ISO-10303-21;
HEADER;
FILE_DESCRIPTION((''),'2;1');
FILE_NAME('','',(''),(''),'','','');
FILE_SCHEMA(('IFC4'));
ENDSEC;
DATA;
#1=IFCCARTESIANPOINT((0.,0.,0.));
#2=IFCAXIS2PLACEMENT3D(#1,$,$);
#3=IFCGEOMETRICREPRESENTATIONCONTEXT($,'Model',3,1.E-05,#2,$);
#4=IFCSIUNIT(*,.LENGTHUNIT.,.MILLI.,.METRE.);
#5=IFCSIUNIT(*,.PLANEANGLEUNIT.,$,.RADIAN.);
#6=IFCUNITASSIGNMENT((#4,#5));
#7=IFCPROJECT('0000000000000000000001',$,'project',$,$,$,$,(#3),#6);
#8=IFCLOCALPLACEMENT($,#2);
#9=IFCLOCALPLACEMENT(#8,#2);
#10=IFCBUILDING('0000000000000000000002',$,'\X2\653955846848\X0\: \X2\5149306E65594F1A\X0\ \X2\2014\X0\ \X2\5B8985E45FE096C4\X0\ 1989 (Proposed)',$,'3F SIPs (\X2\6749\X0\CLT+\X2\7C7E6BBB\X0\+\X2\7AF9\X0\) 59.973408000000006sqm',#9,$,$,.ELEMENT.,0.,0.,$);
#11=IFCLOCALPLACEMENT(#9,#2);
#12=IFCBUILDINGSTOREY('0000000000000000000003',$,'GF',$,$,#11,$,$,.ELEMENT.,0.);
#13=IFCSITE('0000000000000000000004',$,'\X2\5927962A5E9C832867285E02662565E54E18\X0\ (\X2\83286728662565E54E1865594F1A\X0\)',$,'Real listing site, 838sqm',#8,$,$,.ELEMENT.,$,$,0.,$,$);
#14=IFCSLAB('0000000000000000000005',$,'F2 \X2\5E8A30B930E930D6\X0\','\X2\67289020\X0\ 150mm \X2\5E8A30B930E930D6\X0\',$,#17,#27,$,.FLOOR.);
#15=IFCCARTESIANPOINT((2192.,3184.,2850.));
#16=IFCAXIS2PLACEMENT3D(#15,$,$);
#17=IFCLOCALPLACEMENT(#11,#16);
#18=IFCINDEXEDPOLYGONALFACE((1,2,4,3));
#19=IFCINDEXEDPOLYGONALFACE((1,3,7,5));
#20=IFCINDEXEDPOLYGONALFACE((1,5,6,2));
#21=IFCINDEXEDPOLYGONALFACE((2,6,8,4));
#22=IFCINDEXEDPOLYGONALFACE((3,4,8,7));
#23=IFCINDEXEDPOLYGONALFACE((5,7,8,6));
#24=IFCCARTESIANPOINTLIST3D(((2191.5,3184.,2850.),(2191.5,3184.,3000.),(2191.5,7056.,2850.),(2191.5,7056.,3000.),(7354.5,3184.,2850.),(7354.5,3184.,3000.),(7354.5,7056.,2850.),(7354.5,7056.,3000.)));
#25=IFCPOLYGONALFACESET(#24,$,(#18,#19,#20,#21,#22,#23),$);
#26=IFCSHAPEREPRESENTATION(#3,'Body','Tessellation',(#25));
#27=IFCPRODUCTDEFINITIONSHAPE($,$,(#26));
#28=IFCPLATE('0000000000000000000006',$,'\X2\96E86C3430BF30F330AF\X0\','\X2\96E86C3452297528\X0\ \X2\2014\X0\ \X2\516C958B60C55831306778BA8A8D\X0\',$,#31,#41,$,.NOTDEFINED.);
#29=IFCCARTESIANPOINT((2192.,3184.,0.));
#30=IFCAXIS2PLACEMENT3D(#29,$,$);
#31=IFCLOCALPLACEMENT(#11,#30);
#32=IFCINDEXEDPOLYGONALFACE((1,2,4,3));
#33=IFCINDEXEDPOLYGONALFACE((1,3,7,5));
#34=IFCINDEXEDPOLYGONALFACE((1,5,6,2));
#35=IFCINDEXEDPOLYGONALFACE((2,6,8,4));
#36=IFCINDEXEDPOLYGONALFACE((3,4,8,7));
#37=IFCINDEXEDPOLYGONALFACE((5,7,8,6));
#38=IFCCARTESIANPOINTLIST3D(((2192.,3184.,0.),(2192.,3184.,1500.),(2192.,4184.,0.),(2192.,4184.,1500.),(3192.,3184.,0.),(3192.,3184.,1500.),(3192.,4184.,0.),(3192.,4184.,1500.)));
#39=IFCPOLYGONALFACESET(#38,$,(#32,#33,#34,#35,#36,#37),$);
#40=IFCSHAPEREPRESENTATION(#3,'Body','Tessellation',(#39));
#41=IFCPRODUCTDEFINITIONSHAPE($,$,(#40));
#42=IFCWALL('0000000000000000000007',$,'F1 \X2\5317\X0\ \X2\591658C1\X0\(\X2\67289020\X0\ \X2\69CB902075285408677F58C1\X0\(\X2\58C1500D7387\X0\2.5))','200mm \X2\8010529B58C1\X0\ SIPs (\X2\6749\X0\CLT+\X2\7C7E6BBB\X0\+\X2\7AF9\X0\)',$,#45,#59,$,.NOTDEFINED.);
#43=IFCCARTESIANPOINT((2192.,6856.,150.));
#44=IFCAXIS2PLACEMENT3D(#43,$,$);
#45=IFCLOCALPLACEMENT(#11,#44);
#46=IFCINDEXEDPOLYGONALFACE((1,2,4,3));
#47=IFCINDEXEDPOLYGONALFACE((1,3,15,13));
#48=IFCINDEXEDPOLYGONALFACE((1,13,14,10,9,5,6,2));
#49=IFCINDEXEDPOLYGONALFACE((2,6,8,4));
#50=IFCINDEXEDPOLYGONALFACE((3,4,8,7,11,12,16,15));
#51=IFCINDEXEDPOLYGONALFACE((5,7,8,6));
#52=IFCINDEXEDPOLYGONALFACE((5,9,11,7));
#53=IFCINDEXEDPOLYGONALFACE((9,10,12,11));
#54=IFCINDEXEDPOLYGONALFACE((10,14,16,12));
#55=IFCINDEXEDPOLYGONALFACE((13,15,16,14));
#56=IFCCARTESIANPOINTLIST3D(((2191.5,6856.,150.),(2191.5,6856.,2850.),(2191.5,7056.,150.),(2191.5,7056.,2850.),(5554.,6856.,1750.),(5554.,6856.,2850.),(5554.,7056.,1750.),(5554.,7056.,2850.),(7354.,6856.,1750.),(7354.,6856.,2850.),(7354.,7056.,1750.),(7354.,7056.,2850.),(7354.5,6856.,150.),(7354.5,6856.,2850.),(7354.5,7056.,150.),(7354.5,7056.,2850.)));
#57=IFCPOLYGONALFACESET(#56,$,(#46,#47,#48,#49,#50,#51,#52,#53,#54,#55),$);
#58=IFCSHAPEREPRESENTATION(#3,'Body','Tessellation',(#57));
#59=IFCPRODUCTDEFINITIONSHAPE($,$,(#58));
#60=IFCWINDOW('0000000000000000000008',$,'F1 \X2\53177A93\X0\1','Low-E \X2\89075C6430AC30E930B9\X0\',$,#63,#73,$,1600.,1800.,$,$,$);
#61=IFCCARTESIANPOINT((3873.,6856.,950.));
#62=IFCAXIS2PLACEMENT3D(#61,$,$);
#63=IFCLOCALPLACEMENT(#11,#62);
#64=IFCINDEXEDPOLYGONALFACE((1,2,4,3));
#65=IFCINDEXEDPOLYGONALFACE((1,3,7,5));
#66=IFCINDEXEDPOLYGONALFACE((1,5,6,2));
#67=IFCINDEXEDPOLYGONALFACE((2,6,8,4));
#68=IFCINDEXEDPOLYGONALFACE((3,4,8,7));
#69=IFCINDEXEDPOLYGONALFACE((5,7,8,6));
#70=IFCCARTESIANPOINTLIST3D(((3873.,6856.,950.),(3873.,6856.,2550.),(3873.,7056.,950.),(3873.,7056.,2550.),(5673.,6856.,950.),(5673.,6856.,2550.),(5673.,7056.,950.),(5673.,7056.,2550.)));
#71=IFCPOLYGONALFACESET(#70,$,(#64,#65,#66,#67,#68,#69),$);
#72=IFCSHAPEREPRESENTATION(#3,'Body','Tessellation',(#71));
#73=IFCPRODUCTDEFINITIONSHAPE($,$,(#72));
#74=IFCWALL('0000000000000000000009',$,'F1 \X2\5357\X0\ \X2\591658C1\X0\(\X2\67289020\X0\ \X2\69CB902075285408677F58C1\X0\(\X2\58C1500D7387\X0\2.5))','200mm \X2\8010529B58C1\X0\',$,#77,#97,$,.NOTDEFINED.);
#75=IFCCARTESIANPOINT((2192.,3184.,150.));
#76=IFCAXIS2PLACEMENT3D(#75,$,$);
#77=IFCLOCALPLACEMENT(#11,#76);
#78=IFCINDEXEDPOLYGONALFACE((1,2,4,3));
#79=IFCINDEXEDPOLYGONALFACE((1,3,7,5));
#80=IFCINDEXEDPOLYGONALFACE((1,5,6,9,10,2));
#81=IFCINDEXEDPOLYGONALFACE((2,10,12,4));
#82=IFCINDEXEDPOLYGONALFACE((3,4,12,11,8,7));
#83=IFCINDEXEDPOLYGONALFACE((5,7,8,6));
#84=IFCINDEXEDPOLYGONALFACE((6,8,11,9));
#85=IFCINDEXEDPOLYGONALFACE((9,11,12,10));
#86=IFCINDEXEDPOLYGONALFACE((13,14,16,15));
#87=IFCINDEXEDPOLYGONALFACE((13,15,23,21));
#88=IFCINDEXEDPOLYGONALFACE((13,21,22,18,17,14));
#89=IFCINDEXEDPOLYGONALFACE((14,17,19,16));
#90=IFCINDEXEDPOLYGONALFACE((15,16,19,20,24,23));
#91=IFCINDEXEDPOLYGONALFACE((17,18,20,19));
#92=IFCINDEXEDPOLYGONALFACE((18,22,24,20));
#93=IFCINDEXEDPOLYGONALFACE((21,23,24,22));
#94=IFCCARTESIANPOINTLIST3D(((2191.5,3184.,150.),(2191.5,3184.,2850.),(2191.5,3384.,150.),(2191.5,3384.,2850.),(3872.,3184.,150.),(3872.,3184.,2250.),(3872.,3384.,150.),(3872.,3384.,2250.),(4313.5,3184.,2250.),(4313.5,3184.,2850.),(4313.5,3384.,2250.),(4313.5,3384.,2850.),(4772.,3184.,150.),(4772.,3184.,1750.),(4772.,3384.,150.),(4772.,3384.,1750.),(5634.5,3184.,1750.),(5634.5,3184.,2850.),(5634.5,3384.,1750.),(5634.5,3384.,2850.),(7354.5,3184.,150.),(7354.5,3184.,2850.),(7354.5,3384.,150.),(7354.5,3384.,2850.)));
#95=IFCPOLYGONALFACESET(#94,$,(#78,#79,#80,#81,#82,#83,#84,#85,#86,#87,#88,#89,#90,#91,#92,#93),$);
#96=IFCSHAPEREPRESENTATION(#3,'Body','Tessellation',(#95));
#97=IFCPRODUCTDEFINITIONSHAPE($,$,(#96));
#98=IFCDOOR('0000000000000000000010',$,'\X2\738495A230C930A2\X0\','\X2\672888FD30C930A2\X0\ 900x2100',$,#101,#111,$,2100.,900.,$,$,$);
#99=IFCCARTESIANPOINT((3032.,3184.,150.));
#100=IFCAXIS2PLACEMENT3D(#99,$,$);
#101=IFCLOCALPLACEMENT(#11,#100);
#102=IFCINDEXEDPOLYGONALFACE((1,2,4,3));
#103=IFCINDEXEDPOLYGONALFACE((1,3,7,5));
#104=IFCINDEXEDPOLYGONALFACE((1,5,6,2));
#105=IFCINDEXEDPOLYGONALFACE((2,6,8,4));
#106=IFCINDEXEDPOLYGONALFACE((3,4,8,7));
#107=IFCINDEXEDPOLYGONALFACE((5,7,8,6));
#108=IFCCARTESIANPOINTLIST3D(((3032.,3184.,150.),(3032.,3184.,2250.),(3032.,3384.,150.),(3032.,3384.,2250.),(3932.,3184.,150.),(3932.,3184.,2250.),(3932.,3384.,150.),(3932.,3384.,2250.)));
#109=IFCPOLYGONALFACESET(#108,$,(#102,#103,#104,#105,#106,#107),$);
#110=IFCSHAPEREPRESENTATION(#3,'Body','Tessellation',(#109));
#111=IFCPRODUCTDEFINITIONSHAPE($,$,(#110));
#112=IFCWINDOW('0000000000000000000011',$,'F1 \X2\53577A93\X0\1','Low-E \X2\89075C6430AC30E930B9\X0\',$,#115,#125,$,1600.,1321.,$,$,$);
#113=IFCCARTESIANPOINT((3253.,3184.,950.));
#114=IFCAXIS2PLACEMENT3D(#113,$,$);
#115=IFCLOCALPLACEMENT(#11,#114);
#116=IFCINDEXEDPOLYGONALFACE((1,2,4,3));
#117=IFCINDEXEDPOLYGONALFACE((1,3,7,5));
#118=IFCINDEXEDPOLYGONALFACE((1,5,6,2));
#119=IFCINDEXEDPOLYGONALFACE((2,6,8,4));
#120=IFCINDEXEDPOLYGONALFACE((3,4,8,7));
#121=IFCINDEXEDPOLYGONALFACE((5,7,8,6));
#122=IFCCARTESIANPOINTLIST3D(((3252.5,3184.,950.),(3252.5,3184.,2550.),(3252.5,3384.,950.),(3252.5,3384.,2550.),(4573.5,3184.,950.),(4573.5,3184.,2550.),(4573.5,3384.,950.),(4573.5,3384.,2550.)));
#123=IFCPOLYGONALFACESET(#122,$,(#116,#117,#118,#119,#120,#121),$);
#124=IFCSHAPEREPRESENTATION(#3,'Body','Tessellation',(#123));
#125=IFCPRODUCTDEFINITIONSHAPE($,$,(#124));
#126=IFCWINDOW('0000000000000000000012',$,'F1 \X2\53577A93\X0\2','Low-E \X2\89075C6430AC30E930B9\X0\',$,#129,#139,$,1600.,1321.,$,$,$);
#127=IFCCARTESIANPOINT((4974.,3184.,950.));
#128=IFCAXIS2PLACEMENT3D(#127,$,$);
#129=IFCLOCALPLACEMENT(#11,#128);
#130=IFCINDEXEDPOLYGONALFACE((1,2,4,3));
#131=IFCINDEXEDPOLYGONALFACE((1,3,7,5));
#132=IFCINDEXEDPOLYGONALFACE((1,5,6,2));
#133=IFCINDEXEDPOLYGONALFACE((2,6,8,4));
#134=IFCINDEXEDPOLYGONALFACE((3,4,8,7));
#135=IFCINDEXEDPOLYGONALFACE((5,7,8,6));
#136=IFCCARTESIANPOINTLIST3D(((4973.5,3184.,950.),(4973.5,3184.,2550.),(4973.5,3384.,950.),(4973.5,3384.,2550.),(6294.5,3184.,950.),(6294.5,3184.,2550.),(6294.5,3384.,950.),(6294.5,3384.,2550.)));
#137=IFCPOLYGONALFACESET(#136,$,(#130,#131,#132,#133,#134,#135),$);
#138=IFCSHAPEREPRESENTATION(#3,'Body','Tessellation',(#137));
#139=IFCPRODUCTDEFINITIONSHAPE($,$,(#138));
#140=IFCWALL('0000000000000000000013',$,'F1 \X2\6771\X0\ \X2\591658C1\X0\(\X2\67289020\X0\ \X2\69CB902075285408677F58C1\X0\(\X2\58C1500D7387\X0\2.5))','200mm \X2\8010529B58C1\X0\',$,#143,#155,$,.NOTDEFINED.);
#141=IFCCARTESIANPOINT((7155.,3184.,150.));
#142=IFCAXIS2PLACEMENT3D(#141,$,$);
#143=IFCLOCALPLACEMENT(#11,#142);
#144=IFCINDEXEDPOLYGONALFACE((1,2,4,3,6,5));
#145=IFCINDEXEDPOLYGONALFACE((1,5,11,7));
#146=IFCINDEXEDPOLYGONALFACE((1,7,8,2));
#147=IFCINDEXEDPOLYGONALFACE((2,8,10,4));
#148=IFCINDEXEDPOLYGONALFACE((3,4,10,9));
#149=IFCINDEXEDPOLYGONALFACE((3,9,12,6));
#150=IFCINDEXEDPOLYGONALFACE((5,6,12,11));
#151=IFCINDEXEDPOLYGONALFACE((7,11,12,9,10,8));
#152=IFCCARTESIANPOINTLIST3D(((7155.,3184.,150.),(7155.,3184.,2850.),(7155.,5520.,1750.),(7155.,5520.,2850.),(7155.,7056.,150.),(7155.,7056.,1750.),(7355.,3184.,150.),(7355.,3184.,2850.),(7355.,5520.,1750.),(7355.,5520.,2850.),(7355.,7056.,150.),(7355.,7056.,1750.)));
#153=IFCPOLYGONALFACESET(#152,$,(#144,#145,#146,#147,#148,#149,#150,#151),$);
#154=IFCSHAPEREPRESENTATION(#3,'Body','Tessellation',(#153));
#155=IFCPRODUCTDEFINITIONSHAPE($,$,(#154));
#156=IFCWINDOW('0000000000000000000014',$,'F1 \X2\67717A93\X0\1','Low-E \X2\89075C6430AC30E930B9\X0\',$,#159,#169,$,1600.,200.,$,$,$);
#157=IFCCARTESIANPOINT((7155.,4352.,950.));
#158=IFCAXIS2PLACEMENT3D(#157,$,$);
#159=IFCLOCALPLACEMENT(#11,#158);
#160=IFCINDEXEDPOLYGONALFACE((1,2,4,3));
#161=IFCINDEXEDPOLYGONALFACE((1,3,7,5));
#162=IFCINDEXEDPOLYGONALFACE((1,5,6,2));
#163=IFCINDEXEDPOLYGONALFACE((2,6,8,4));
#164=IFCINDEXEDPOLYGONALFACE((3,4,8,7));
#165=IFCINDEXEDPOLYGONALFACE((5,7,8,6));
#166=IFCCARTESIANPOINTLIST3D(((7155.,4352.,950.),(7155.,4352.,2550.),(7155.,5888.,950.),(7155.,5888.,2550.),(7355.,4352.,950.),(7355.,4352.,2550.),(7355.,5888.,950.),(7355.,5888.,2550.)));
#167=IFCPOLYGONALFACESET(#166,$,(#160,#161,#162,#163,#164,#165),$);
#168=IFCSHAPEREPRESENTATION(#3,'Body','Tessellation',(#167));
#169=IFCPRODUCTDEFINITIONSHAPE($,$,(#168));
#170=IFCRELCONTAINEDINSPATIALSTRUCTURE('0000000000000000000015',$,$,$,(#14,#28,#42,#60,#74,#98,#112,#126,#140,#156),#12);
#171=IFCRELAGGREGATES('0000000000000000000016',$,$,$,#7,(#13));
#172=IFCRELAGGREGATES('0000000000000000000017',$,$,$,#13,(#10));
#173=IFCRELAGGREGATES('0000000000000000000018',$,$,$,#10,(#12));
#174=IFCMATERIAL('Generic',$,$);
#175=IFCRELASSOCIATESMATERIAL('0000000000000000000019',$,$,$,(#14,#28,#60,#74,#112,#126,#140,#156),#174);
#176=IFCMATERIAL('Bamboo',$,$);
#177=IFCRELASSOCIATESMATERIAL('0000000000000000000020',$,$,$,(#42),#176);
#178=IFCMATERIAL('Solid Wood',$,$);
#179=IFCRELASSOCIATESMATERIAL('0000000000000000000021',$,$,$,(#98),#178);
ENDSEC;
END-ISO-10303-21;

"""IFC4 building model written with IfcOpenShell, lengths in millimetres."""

from ifc_helpers import new_model, si_unit, frame, frame_2d, origin, place, context, project, spatial, rectangle, extrude, material, element, fill, save


model = new_model("IFC4")

# Units and contexts
model_context = context("Model", 3, precision=1e-05, world=origin())
ifc_project = project(units=[si_unit("LENGTHUNIT", "METRE", prefix="MILLI"), si_unit("PLANEANGLEUNIT", "RADIAN")], contexts=[model_context])

# Site, building, storey
site_placement = place(None, origin())
site = spatial("IfcSite", under=ifc_project, at=site_placement, Name="大阪府茨木市春日丘 (茨木春日丘教会)", ObjectType="Real listing site, 838sqm", CompositionType="ELEMENT", RefElevation=0.0)
building_placement = place(site_placement, origin())
building = spatial("IfcBuilding", under=site, at=building_placement, Name="改善案: 光の教会 — 安藤忠雄 1989 (Proposed)", ObjectType="3F SIPs (杉CLT+籾殻+竹) 59.973408000000006sqm", CompositionType="ELEMENT", ElevationOfRefHeight=0.0, ElevationOfTerrain=0.0)
storey_placement = place(building_placement, origin())
storey = spatial("IfcBuildingStorey", under=building, at=storey_placement, Name="GF", CompositionType="ELEMENT", Elevation=0.0)

# Slab
ifc_material_1 = material(Name="Generic")
slab_1_placement = place(storey_placement, frame((2192.0, 3184.0, 2850.0)))
element("IfcSlab", 1, at=slab_1_placement, inside=storey, material=ifc_material_1, Name="F2 床スラブ", Description="木造 150mm 床スラブ", PredefinedType="FLOOR", context=model_context, shape_type="SweptSolid", body=[
    extrude(rectangle(XDim=5163.0, YDim=3872.0, at=frame_2d((2581.0, 1936.0))), frame((2192.0, 3184.0, 2850.0)), (0.0, 0.0, 1.0), 150.0),
])

# Plate
plate_placement = place(storey_placement, frame((2192.0, 3184.0, 0.0)))
element("IfcPlate", 2, at=plate_placement, inside=storey, material=ifc_material_1, Name="雨水タンク", Description="雨水利用 — 公開情報で確認", PredefinedType="NOTDEFINED", context=model_context, shape_type="SweptSolid", body=[
    extrude(rectangle(XDim=1000.0, YDim=1000.0, at=frame_2d((500.0, 500.0))), frame((2192.0, 3184.0, 0.0)), (0.0, 0.0, 1.0), 1500.0),
])

# Wall, opening, window
ifc_material_2 = material(Name="Bamboo")
wall_1_placement = place(storey_placement, frame((2192.0, 6856.0, 150.0)))
wall_1 = element("IfcWall", 3, at=wall_1_placement, inside=storey, material=ifc_material_2, Name="F1 北 外壁(木造 構造用合板壁(壁倍率2.5))", Description="200mm 耐力壁 SIPs (杉CLT+籾殻+竹)", PredefinedType="NOTDEFINED", context=model_context, shape_type="SweptSolid", body=[
    extrude(rectangle(XDim=5163.0, YDim=200.0, at=frame_2d((2581.0, 100.0))), frame((2192.0, 6856.0, 150.0)), (0.0, 0.0, 1.0), 2700.0),
])
opening_1_placement = place(storey_placement, frame((3873.0, 6856.0, 950.0)))
opening_1 = element("IfcOpeningElement", 4, at=opening_1_placement, cuts=wall_1, PredefinedType="NOTDEFINED", context=model_context, shape_type="SweptSolid", body=[
    extrude(rectangle(XDim=1800.0, YDim=200.0, at=frame_2d((900.0, 100.0))), frame((3873.0, 6856.0, 950.0)), (0.0, 0.0, 1.0), 1600.0),
])
window_1_placement = place(storey_placement, frame((3873.0, 6856.0, 950.0)))
window_1 = element("IfcWindow", 5, at=window_1_placement, inside=storey, material=ifc_material_1, Name="F1 北窓1", Description="Low-E 複層ガラス", OverallHeight=1600.0, OverallWidth=1800.0, context=model_context, shape_type="SweptSolid", body=[
    extrude(rectangle(XDim=1800.0, YDim=200.0, at=frame_2d((900.0, 100.0))), frame((3873.0, 6856.0, 950.0)), (0.0, 0.0, 1.0), 1600.0),
])
fill(opening_1, window_1)

# Wall, openings, door, windows
wall_2_placement = place(storey_placement, frame((2192.0, 3184.0, 150.0)))
wall_2 = element("IfcWall", 6, at=wall_2_placement, inside=storey, material=ifc_material_1, Name="F1 南 外壁(木造 構造用合板壁(壁倍率2.5))", Description="200mm 耐力壁", PredefinedType="NOTDEFINED", context=model_context, shape_type="SweptSolid", body=[
    extrude(rectangle(XDim=5163.0, YDim=200.0, at=frame_2d((2581.0, 100.0))), frame((2192.0, 3184.0, 150.0)), (0.0, 0.0, 1.0), 2700.0),
])
opening_2_placement = place(storey_placement, frame((3032.0, 3184.0, 150.0)))
opening_2 = element("IfcOpeningElement", 7, at=opening_2_placement, cuts=wall_2, PredefinedType="NOTDEFINED", context=model_context, shape_type="SweptSolid", body=[
    extrude(rectangle(XDim=900.0, YDim=200.0, at=frame_2d((450.0, 100.0))), frame((3032.0, 3184.0, 150.0)), (0.0, 0.0, 1.0), 2100.0),
])
opening_3_placement = place(storey_placement, frame((3253.0, 3184.0, 950.0)))
opening_3 = element("IfcOpeningElement", 8, at=opening_3_placement, cuts=wall_2, PredefinedType="NOTDEFINED", context=model_context, shape_type="SweptSolid", body=[
    extrude(rectangle(XDim=1321.0, YDim=200.0, at=frame_2d((660.0, 100.0))), frame((3253.0, 3184.0, 950.0)), (0.0, 0.0, 1.0), 1600.0),
])
opening_4_placement = place(storey_placement, frame((4974.0, 3184.0, 950.0)))
opening_4 = element("IfcOpeningElement", 9, at=opening_4_placement, cuts=wall_2, PredefinedType="NOTDEFINED", context=model_context, shape_type="SweptSolid", body=[
    extrude(rectangle(XDim=1321.0, YDim=200.0, at=frame_2d((660.0, 100.0))), frame((4974.0, 3184.0, 950.0)), (0.0, 0.0, 1.0), 1600.0),
])
ifc_material_3 = material(Name="Solid Wood")
door_placement = place(storey_placement, frame((3032.0, 3184.0, 150.0)))
door = element("IfcDoor", 10, at=door_placement, inside=storey, material=ifc_material_3, Name="玄関ドア", Description="木製ドア 900x2100", OverallHeight=2100.0, OverallWidth=900.0, context=model_context, shape_type="SweptSolid", body=[
    extrude(rectangle(XDim=900.0, YDim=200.0, at=frame_2d((450.0, 100.0))), frame((3032.0, 3184.0, 150.0)), (0.0, 0.0, 1.0), 2100.0),
])
fill(opening_2, door)
window_2_placement = place(storey_placement, frame((3253.0, 3184.0, 950.0)))
window_2 = element("IfcWindow", 11, at=window_2_placement, inside=storey, material=ifc_material_1, Name="F1 南窓1", Description="Low-E 複層ガラス", OverallHeight=1600.0, OverallWidth=1321.0, context=model_context, shape_type="SweptSolid", body=[
    extrude(rectangle(XDim=1321.0, YDim=200.0, at=frame_2d((660.0, 100.0))), frame((3253.0, 3184.0, 950.0)), (0.0, 0.0, 1.0), 1600.0),
])
fill(opening_3, window_2)
window_3_placement = place(storey_placement, frame((4974.0, 3184.0, 950.0)))
window_3 = element("IfcWindow", 12, at=window_3_placement, inside=storey, material=ifc_material_1, Name="F1 南窓2", Description="Low-E 複層ガラス", OverallHeight=1600.0, OverallWidth=1321.0, context=model_context, shape_type="SweptSolid", body=[
    extrude(rectangle(XDim=1321.0, YDim=200.0, at=frame_2d((660.0, 100.0))), frame((4974.0, 3184.0, 950.0)), (0.0, 0.0, 1.0), 1600.0),
])
fill(opening_4, window_3)

# Wall, opening, window
wall_3_placement = place(storey_placement, frame((7155.0, 3184.0, 150.0)))
wall_3 = element("IfcWall", 13, at=wall_3_placement, inside=storey, material=ifc_material_1, Name="F1 東 外壁(木造 構造用合板壁(壁倍率2.5))", Description="200mm 耐力壁", PredefinedType="NOTDEFINED", context=model_context, shape_type="SweptSolid", body=[
    extrude(rectangle(XDim=200.0, YDim=3872.0, at=frame_2d((100.0, 1936.0))), frame((7155.0, 3184.0, 150.0)), (0.0, 0.0, 1.0), 2700.0),
])
opening_5_placement = place(storey_placement, frame((7155.0, 4352.0, 950.0)))
opening_5 = element("IfcOpeningElement", 14, at=opening_5_placement, cuts=wall_3, PredefinedType="NOTDEFINED", context=model_context, shape_type="SweptSolid", body=[
    extrude(rectangle(XDim=200.0, YDim=1536.0, at=frame_2d((100.0, 768.0))), frame((7155.0, 4352.0, 950.0)), (0.0, 0.0, 1.0), 1600.0),
])
window_4_placement = place(storey_placement, frame((7155.0, 4352.0, 950.0)))
window_4 = element("IfcWindow", 15, at=window_4_placement, inside=storey, material=ifc_material_1, Name="F1 東窓1", Description="Low-E 複層ガラス", OverallHeight=1600.0, OverallWidth=200.0, context=model_context, shape_type="SweptSolid", body=[
    extrude(rectangle(XDim=200.0, YDim=1536.0, at=frame_2d((100.0, 768.0))), frame((7155.0, 4352.0, 950.0)), (0.0, 0.0, 1.0), 1600.0),
])
fill(opening_5, window_4)

save(model, "model.ifc")
